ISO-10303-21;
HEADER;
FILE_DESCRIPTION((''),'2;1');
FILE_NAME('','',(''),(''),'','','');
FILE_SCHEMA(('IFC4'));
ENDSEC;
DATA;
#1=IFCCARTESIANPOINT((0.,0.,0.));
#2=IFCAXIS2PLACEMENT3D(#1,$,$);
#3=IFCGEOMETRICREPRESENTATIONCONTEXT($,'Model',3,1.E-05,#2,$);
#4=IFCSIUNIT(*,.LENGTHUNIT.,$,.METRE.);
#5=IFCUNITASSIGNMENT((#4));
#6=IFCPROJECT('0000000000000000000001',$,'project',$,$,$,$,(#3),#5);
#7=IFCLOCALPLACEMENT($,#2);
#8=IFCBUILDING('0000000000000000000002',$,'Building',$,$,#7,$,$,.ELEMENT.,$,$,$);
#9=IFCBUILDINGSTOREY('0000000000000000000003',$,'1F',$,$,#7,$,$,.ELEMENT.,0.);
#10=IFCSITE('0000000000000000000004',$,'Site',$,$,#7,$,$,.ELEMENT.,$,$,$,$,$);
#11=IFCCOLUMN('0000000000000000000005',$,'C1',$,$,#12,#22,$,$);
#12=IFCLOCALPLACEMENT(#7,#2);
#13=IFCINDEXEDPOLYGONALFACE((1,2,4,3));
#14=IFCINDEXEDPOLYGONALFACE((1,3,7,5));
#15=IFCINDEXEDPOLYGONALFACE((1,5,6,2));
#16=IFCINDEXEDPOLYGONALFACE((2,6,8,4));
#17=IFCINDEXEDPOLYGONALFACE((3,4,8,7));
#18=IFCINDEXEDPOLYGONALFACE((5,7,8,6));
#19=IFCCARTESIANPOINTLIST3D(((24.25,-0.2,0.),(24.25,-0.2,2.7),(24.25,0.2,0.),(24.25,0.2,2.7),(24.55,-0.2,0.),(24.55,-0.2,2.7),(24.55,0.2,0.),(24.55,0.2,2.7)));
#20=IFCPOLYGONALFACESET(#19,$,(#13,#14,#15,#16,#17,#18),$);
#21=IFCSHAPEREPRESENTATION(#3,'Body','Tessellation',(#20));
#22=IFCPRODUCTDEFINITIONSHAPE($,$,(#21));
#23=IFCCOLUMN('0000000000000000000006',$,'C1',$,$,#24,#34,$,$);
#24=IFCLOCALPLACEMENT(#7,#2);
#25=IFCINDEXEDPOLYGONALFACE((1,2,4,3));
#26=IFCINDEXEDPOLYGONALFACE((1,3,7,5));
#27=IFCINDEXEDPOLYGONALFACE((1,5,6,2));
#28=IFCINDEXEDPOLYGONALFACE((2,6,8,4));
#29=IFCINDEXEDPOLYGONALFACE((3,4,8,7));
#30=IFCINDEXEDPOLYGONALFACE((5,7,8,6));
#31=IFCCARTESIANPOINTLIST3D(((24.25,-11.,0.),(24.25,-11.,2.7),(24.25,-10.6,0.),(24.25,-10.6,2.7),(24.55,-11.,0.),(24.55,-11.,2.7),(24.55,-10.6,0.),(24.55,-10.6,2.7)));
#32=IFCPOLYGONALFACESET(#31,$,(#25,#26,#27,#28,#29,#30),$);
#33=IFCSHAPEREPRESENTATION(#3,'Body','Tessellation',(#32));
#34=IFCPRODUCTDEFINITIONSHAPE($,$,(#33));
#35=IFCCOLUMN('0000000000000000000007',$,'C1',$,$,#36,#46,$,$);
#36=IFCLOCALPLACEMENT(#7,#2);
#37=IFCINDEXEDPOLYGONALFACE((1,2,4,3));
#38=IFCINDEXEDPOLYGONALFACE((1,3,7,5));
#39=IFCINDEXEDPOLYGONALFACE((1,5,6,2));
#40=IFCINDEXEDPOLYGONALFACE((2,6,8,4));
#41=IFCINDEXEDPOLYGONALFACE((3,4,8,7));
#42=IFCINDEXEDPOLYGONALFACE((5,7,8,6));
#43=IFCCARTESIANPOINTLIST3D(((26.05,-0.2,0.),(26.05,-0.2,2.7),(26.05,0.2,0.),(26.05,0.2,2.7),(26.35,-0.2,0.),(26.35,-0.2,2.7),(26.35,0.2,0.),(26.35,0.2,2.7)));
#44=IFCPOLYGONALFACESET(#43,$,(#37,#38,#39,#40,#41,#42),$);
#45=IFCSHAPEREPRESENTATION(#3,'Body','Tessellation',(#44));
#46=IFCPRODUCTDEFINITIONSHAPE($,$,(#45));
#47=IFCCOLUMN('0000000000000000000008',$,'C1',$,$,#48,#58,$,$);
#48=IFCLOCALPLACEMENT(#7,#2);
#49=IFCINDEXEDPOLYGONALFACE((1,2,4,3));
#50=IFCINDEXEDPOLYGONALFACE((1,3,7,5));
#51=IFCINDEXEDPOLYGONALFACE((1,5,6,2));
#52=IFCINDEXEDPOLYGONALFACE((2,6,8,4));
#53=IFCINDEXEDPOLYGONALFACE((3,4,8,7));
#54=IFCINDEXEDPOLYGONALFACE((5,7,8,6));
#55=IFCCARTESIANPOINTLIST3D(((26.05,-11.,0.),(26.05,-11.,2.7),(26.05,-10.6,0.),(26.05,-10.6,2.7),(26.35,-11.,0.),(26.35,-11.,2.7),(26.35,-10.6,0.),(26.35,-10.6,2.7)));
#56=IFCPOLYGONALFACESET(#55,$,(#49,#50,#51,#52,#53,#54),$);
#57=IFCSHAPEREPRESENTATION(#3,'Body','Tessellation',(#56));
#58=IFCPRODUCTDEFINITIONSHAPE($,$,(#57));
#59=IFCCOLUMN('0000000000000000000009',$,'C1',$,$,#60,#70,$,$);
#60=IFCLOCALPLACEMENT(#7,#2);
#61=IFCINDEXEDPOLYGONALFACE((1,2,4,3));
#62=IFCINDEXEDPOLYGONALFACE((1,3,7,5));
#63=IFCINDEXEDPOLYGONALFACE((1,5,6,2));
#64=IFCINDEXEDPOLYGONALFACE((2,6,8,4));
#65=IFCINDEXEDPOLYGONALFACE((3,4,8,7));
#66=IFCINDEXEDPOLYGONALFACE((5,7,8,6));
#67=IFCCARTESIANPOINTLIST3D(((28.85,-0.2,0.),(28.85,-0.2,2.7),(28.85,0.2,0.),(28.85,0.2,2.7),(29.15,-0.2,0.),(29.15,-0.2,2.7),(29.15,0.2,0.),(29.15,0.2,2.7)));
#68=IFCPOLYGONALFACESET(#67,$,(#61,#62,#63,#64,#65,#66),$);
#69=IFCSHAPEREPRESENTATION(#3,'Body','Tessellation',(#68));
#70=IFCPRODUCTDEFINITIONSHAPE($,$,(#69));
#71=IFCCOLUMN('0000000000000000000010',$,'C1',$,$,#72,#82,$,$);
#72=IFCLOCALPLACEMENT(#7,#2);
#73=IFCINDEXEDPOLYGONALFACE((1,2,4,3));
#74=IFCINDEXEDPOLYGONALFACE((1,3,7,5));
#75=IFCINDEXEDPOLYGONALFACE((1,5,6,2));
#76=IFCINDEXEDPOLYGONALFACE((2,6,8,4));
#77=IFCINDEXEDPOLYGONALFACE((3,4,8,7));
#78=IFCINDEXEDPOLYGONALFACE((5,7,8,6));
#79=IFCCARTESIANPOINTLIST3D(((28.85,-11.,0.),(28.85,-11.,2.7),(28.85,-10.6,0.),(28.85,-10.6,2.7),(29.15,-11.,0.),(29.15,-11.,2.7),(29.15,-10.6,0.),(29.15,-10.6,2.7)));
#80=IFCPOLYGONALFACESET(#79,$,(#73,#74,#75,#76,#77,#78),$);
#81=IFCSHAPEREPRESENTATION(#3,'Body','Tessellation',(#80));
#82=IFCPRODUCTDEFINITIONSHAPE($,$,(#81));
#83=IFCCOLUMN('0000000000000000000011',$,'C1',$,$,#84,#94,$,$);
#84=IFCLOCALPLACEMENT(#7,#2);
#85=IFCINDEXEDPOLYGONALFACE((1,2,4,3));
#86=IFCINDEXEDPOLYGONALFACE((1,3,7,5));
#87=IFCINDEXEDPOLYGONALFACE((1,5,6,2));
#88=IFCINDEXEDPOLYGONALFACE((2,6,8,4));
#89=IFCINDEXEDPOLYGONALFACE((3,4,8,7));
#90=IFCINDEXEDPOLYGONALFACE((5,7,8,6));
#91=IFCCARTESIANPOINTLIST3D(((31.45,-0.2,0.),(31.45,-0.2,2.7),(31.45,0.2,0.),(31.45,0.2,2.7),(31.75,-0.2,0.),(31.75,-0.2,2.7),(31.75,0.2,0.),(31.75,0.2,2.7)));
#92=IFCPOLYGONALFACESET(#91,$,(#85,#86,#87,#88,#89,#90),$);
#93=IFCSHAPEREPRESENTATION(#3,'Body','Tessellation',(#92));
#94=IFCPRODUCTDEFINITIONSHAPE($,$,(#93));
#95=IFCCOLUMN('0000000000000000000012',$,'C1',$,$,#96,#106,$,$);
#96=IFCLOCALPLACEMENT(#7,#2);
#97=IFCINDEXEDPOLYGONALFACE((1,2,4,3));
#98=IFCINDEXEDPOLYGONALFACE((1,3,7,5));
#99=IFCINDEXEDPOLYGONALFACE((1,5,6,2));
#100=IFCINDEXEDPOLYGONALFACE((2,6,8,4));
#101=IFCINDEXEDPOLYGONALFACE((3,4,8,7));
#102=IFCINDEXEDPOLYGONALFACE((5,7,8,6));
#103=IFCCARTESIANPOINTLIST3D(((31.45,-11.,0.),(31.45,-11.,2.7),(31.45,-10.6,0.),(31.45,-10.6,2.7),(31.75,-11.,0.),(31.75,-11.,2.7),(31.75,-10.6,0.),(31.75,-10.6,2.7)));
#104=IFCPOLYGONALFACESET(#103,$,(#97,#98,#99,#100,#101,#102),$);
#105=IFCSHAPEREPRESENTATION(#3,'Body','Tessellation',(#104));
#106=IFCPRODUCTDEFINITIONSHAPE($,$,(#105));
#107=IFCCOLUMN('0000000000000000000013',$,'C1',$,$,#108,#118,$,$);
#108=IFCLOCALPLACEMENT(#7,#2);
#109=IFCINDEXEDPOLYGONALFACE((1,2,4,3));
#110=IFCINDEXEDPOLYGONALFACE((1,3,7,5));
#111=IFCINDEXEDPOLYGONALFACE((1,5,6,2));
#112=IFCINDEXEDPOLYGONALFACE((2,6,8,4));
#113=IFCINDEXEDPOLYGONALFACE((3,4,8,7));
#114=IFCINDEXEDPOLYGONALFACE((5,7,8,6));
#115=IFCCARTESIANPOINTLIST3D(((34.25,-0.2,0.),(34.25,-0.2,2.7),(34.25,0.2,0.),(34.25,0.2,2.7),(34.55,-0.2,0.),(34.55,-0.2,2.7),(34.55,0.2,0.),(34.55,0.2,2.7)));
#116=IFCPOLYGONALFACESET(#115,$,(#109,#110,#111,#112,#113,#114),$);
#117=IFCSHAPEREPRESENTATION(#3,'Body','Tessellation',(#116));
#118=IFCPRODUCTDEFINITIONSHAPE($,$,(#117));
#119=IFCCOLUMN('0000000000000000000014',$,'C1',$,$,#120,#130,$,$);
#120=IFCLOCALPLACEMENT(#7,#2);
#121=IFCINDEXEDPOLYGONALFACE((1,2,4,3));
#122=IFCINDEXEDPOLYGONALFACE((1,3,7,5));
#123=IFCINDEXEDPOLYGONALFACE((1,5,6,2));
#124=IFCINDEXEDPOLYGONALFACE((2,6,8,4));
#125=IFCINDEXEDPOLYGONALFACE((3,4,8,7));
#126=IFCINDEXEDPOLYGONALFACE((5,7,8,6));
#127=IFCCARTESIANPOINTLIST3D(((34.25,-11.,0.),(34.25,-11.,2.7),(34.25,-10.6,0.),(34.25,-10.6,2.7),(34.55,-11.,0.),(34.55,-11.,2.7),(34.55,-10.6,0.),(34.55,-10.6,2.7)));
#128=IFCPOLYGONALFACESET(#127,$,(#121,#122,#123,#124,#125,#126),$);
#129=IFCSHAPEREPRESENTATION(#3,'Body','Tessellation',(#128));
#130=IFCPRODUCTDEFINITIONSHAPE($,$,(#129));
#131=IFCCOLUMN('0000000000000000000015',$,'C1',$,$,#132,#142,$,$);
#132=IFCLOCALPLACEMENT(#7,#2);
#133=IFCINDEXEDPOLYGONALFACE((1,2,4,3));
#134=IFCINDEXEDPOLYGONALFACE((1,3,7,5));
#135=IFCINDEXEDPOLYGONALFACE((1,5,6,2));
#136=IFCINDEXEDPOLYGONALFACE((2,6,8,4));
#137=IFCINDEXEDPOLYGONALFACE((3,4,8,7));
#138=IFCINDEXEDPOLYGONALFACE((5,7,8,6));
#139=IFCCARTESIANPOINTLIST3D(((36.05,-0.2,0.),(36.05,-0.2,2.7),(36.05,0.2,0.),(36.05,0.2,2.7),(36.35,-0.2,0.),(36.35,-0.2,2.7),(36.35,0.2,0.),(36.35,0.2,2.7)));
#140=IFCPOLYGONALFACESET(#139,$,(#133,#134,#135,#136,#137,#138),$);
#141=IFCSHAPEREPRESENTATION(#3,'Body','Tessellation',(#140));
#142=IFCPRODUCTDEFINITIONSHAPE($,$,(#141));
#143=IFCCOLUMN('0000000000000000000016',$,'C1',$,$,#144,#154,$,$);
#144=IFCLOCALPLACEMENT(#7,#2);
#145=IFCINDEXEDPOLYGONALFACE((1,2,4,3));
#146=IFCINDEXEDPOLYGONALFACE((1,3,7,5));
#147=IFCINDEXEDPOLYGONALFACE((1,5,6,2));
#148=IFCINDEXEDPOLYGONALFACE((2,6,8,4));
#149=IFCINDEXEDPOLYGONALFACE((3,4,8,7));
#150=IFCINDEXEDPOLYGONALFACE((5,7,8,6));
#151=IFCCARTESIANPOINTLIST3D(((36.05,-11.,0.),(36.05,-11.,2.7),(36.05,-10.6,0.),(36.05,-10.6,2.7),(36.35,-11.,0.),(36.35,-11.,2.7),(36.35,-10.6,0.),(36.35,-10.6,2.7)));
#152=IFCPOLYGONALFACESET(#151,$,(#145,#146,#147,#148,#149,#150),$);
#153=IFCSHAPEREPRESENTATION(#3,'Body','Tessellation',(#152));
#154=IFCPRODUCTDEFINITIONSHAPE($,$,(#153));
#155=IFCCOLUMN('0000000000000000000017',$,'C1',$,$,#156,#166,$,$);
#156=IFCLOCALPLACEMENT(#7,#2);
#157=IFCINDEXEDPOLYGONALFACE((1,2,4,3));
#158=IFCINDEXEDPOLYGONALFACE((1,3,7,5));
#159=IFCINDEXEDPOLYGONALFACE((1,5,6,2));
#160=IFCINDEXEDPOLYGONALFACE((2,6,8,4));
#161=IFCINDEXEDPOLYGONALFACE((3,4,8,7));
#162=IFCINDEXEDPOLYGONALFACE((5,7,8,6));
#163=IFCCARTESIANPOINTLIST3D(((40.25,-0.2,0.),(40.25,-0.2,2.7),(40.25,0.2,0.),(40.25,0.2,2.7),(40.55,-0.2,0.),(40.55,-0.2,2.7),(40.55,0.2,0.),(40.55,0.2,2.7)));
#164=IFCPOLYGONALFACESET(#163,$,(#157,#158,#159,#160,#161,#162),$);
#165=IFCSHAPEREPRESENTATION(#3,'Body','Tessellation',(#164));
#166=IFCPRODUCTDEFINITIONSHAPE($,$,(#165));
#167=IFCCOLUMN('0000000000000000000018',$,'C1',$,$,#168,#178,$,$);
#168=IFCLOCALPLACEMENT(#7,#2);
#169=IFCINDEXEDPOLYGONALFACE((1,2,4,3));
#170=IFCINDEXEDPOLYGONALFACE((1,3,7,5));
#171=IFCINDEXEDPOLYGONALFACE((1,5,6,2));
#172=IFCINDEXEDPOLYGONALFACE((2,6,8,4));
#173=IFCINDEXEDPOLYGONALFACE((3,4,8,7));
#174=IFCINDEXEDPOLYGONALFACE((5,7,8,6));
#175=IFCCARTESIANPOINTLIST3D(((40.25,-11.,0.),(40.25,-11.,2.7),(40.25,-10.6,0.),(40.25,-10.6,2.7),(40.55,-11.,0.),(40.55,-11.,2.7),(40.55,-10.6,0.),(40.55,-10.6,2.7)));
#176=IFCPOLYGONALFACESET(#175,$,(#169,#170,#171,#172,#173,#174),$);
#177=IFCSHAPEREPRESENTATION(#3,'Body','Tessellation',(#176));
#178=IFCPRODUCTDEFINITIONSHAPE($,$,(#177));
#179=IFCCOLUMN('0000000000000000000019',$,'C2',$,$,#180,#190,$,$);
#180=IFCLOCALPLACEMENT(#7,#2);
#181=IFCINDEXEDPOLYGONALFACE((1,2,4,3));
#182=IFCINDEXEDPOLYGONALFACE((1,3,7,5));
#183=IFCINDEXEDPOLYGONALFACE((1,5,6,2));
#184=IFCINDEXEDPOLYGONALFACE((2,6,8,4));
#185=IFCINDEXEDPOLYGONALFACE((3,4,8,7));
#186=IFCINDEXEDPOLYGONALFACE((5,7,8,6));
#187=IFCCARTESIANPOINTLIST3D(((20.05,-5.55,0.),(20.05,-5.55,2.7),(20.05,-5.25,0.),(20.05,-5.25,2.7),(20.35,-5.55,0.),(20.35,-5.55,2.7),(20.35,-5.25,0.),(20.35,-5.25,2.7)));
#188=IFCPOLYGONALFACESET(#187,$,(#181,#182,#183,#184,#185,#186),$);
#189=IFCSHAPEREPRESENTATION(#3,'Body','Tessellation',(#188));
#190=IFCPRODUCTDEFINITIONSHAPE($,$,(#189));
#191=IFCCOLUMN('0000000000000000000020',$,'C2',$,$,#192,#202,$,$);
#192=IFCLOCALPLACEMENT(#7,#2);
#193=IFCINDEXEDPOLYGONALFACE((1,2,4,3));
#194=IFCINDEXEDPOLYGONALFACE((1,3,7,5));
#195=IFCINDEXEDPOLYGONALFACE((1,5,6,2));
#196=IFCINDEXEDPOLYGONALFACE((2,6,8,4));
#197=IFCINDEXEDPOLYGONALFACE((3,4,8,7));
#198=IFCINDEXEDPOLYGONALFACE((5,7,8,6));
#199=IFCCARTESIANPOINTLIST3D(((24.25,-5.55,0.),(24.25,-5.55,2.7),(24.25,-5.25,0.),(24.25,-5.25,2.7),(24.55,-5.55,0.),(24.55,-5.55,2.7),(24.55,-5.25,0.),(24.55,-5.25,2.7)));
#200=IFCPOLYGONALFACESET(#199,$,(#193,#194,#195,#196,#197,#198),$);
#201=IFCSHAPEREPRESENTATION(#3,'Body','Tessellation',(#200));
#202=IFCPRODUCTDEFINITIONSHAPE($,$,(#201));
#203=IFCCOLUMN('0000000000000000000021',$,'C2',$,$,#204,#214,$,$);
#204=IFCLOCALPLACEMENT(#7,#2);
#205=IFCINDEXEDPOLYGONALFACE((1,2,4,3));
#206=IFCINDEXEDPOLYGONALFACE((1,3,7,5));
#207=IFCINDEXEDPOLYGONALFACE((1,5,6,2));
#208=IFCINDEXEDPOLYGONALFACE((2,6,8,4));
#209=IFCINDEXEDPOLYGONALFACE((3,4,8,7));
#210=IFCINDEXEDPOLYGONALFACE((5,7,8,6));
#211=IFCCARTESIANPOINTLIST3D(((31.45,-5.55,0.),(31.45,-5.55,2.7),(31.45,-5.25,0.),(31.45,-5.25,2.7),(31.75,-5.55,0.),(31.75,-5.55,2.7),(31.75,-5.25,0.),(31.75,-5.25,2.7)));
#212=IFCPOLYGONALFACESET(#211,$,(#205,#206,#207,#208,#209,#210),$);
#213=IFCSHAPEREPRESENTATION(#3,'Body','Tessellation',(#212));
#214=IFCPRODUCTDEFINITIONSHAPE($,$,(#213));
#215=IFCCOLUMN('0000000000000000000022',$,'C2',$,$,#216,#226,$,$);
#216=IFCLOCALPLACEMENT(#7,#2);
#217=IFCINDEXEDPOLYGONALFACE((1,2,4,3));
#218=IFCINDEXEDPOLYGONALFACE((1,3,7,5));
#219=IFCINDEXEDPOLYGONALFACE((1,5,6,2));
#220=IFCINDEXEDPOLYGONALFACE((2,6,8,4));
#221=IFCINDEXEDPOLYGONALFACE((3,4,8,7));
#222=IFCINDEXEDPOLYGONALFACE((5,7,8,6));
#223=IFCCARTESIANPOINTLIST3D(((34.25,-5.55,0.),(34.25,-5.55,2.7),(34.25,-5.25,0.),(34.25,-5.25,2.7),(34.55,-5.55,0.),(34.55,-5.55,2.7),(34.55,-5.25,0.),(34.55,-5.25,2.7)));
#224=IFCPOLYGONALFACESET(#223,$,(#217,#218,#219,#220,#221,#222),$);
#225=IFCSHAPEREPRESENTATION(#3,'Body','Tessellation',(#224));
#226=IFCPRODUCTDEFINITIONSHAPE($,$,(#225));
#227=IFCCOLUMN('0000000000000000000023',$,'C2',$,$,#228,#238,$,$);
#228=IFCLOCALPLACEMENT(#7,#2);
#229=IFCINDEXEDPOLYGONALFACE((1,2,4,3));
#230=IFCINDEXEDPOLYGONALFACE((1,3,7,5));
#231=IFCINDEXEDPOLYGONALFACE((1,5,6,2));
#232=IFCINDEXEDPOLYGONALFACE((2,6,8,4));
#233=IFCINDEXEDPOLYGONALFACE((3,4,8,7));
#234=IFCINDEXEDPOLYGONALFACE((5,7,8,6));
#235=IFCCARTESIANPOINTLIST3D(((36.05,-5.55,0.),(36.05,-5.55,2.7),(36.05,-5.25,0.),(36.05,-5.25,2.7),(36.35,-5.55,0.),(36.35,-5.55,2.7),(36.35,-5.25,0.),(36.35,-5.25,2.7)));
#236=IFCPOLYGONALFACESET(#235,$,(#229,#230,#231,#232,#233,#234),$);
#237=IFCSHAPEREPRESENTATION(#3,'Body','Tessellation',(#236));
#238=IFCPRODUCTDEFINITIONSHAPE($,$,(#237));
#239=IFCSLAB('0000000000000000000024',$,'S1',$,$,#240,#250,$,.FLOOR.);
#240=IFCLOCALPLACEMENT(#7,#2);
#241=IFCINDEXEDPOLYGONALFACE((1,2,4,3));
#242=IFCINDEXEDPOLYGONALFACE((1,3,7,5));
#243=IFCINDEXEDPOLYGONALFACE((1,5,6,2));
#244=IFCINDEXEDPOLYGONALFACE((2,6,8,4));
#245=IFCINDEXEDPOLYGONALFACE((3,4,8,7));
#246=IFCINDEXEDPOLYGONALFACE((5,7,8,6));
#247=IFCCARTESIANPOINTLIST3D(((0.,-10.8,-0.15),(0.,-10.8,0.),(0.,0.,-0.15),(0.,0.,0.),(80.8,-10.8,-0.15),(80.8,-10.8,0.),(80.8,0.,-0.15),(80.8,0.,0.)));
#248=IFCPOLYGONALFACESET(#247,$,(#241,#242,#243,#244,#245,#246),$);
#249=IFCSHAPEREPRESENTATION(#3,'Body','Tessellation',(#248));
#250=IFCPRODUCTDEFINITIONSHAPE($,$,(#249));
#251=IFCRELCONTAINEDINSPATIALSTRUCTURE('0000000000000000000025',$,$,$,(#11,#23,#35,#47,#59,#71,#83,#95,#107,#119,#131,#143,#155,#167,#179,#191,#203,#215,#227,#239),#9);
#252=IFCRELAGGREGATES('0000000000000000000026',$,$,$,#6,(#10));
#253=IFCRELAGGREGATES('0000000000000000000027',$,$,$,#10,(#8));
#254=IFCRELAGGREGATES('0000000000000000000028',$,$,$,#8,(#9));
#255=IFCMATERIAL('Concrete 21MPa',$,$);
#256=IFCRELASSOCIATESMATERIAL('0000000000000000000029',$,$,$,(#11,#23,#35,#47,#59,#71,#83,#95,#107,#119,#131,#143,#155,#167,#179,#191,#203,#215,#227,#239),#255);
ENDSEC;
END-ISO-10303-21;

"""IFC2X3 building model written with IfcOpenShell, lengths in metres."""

from ifc_helpers import new_model, si_unit, frame, origin, origin_2d, place, context, project, spatial, rectangle, extrude, material, element, save


model = new_model("IFC2X3")

# Units and contexts
model_context = context("Model", 3, precision=1e-05, world=origin())
ifc_project = project(units=[si_unit("LENGTHUNIT", "METRE")], contexts=[model_context])

# Site, building, storey
placement = place(None, origin())
site = spatial("IfcSite", under=ifc_project, at=placement, Name="Site", CompositionType="ELEMENT")
building = spatial("IfcBuilding", under=site, at=placement, Name="Building", CompositionType="ELEMENT")
storey = spatial("IfcBuildingStorey", under=building, at=placement, Name="1F", CompositionType="ELEMENT", Elevation=0.0)

# Columns
ifc_material_1 = material(Name="Concrete 21MPa")
for number, where, name in (
    (1, (24.4, 0.0, 0.0), "C1"),
    (2, (24.4, -10.8, 0.0), "C1"),
    (3, (26.2, 0.0, 0.0), "C1"),
    (4, (26.2, -10.8, 0.0), "C1"),
    (5, (29.0, 0.0, 0.0), "C1"),
    (6, (29.0, -10.8, 0.0), "C1"),
    (7, (31.6, 0.0, 0.0), "C1"),
    (8, (31.6, -10.8, 0.0), "C1"),
    (9, (34.4, 0.0, 0.0), "C1"),
    (10, (34.4, -10.8, 0.0), "C1"),
    (11, (36.2, 0.0, 0.0), "C1"),
    (12, (36.2, -10.8, 0.0), "C1"),
    (13, (40.4, 0.0, 0.0), "C1"),
    (14, (40.4, -10.8, 0.0), "C1"),
):
    element("IfcColumn", number, at=place(None, frame(where)), inside=storey, material=ifc_material_1, Name=name, context=model_context, shape_type="SweptSolid", body=[
        extrude(rectangle(XDim=0.3, YDim=0.4, at=origin_2d()), origin(), (0.0, 0.0, 1.0), 2.7),
    ])
for number, where, name in (
    (15, (20.2, -5.4, 0.0), "C2"),
    (16, (24.4, -5.4, 0.0), "C2"),
    (17, (31.6, -5.4, 0.0), "C2"),
    (18, (34.4, -5.4, 0.0), "C2"),
    (19, (36.2, -5.4, 0.0), "C2"),
):
    element("IfcColumn", number, at=place(None, frame(where)), inside=storey, material=ifc_material_1, Name=name, context=model_context, shape_type="SweptSolid", body=[
        extrude(rectangle(XDim=0.3, YDim=0.3, at=origin_2d()), origin(), (0.0, 0.0, 1.0), 2.7),
    ])

# Slab
slab_placement = place(None, frame((40.4, -5.4, -0.15)))
element("IfcSlab", 20, at=slab_placement, inside=storey, material=ifc_material_1, Name="S1", PredefinedType="FLOOR", context=model_context, shape_type="SweptSolid", body=[
    extrude(rectangle(XDim=80.8, YDim=10.8, at=origin_2d()), origin(), (0.0, 0.0, 1.0), 0.15),
])

save(model, "model.ifc")
